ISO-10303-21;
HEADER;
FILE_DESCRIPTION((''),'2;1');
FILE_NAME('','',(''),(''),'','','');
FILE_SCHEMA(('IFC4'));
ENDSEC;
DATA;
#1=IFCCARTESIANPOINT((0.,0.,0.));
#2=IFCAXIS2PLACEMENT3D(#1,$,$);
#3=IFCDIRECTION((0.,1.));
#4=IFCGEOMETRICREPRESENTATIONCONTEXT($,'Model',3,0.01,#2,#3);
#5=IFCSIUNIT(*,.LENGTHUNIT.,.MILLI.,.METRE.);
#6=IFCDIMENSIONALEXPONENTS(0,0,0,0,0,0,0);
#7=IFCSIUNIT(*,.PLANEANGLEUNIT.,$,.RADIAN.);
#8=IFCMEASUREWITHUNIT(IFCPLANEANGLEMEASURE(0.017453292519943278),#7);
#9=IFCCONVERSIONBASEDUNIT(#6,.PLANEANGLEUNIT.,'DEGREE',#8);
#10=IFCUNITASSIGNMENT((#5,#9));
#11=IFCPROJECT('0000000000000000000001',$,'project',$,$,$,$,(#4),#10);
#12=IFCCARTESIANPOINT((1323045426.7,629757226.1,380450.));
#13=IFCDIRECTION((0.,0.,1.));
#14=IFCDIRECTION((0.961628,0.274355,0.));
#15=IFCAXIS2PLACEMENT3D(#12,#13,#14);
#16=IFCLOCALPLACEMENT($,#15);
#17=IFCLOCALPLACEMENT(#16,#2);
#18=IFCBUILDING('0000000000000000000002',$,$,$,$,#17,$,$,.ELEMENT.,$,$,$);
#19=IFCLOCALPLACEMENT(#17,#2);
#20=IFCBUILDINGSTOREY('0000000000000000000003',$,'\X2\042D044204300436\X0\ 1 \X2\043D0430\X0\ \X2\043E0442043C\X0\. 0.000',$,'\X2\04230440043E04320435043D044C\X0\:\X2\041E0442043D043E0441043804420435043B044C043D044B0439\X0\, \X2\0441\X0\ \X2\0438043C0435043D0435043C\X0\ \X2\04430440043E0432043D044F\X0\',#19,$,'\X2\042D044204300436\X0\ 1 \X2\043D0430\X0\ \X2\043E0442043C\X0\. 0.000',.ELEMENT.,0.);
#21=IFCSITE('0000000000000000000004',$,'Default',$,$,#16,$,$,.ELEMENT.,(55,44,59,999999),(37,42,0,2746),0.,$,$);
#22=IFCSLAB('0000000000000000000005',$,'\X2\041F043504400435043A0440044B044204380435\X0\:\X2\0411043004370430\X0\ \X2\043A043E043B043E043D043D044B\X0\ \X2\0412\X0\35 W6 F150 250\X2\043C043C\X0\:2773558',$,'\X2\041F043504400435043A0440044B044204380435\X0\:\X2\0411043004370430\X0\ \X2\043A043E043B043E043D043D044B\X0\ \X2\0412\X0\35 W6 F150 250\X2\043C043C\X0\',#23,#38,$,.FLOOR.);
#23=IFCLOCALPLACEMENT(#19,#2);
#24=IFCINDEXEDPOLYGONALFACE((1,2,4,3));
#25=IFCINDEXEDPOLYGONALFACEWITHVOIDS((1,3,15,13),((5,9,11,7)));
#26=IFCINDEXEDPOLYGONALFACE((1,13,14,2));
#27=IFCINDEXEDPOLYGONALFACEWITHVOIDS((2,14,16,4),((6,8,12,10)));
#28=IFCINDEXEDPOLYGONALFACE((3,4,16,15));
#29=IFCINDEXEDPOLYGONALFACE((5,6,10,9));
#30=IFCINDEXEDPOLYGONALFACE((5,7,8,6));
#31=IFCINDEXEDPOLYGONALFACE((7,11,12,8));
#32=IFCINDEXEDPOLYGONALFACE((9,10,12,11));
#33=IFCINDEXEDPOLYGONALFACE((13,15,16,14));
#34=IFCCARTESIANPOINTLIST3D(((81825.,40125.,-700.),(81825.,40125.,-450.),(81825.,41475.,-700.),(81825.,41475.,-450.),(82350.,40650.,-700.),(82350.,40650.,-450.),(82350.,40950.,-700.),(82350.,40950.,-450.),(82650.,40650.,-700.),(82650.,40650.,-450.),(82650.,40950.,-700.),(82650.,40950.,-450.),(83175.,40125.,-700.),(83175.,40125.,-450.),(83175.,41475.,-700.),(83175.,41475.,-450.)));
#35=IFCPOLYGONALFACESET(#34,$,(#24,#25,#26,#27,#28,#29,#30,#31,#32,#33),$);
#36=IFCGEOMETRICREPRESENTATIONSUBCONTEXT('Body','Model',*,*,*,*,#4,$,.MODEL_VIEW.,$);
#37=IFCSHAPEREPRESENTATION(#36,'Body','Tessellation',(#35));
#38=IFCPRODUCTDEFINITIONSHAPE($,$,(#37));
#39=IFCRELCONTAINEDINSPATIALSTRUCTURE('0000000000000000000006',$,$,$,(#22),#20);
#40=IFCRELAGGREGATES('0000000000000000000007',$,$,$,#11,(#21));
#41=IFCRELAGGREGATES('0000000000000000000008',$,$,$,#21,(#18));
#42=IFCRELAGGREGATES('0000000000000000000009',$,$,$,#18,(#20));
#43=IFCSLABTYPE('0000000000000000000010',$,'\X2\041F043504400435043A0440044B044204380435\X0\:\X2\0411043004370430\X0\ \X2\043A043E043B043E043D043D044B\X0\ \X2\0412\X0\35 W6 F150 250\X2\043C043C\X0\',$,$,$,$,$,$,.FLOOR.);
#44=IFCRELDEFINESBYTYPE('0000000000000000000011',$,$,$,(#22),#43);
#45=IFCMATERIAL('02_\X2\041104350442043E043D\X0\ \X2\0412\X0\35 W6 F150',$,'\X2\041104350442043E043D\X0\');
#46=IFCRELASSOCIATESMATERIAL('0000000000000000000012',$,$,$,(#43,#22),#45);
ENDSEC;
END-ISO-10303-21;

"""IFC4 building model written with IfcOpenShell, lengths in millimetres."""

from ifc_helpers import new_model, entity, si_unit, converted_unit, direction, frame, origin, place, context, subcontext, project, spatial, indexed_curve, outline, extrude, material, type_object, element, save


model = new_model("IFC4")

# Units and contexts
model_context = context("Model", 3, precision=0.01, world=origin(), true_north=direction((0.0, 1.0)))
body_context = subcontext(model_context, "Body", "Model", "MODEL_VIEW")
ifc_project = project(units=[si_unit("LENGTHUNIT", "METRE", prefix="MILLI"), converted_unit("PLANEANGLEUNIT", "DEGREE", entity("IfcPlaneAngleMeasure", 0.017453292519943278), si_unit("PLANEANGLEUNIT", "RADIAN"), dimensions=[0, 0, 0, 0, 0, 0, 0])], contexts=[model_context])

# Site, building, storey
site_placement = place(None, frame((1323045426.7, 629757226.1, 380450.0), z_axis=(0.0, 0.0, 1.0), x_axis=(0.961628, 0.274355, 0.0)))
site = spatial("IfcSite", under=ifc_project, at=site_placement, Name="Default", CompositionType="ELEMENT", RefLatitude=(55, 44, 59, 999999), RefLongitude=(37, 42, 0, 2746), RefElevation=0.0)
building_placement = place(site_placement, origin())
building = spatial("IfcBuilding", under=site, at=building_placement, CompositionType="ELEMENT")
storey_placement = place(building_placement, origin())
storey = spatial("IfcBuildingStorey", under=building, at=storey_placement, Name="Этаж 1 на отм. 0.000", ObjectType="Уровень:Относительный, с именем уровня", LongName="Этаж 1 на отм. 0.000", CompositionType="ELEMENT", Elevation=0.0)

# Shared definitions
ifc_material = material(Name="02_Бетон В35 W6 F150", Category="Бетон")

# Slab, opening
slab_type_1 = type_object("IfcSlabType", Name="Перекрытие:База колонны В35 W6 F150 250мм", PredefinedType="FLOOR", material=ifc_material)
slab_1_placement = place(storey_placement, origin())
slab_1 = element("IfcSlab", 1, at=slab_1_placement, inside=storey, type_object=slab_type_1, material=ifc_material, Name="Перекрытие:База колонны В35 W6 F150 250мм:2773558", ObjectType="Перекрытие:База колонны В35 W6 F150 250мм", PredefinedType="FLOOR", context=body_context, shape_type="SweptSolid", body=[
    extrude(outline(indexed_curve([(-675.0, -675.0), (675.0, -675.0), (675.0, 675.0), (-675.0, 675.0), (-675.0, -675.0)], self_intersect=False), holes=[indexed_curve([(-150.0, 150.0), (150.0, 150.0), (150.0, -150.0), (-150.0, -150.0), (-150.0, 150.0)], self_intersect=False)]), frame((82500.0, 40800.0, -700.0), z_axis=(0.0, 0.0, 1.0), x_axis=(-1.0, 0.0, 0.0)), (0.0, 0.0, 1.0), 250.0),
])
opening_1_placement = place(slab_1_placement, origin())
element("IfcOpeningElement", 2, at=opening_1_placement, cuts=slab_1, PredefinedType="RECESS", context=body_context, shape_type="SweptSolid", body=[
    extrude(outline(indexed_curve([(-150.0, -150.0), (150.0, -150.0), (150.0, 150.0), (-150.0, 150.0), (-150.0, -150.0)], self_intersect=False)), frame((82500.0, 40800.0, -700.0), z_axis=(0.0, 0.0, 1.0), x_axis=(0.0, 1.0, 0.0)), (0.0, 0.0, 1.0), 500.0),
])

save(model, "model.ifc")
